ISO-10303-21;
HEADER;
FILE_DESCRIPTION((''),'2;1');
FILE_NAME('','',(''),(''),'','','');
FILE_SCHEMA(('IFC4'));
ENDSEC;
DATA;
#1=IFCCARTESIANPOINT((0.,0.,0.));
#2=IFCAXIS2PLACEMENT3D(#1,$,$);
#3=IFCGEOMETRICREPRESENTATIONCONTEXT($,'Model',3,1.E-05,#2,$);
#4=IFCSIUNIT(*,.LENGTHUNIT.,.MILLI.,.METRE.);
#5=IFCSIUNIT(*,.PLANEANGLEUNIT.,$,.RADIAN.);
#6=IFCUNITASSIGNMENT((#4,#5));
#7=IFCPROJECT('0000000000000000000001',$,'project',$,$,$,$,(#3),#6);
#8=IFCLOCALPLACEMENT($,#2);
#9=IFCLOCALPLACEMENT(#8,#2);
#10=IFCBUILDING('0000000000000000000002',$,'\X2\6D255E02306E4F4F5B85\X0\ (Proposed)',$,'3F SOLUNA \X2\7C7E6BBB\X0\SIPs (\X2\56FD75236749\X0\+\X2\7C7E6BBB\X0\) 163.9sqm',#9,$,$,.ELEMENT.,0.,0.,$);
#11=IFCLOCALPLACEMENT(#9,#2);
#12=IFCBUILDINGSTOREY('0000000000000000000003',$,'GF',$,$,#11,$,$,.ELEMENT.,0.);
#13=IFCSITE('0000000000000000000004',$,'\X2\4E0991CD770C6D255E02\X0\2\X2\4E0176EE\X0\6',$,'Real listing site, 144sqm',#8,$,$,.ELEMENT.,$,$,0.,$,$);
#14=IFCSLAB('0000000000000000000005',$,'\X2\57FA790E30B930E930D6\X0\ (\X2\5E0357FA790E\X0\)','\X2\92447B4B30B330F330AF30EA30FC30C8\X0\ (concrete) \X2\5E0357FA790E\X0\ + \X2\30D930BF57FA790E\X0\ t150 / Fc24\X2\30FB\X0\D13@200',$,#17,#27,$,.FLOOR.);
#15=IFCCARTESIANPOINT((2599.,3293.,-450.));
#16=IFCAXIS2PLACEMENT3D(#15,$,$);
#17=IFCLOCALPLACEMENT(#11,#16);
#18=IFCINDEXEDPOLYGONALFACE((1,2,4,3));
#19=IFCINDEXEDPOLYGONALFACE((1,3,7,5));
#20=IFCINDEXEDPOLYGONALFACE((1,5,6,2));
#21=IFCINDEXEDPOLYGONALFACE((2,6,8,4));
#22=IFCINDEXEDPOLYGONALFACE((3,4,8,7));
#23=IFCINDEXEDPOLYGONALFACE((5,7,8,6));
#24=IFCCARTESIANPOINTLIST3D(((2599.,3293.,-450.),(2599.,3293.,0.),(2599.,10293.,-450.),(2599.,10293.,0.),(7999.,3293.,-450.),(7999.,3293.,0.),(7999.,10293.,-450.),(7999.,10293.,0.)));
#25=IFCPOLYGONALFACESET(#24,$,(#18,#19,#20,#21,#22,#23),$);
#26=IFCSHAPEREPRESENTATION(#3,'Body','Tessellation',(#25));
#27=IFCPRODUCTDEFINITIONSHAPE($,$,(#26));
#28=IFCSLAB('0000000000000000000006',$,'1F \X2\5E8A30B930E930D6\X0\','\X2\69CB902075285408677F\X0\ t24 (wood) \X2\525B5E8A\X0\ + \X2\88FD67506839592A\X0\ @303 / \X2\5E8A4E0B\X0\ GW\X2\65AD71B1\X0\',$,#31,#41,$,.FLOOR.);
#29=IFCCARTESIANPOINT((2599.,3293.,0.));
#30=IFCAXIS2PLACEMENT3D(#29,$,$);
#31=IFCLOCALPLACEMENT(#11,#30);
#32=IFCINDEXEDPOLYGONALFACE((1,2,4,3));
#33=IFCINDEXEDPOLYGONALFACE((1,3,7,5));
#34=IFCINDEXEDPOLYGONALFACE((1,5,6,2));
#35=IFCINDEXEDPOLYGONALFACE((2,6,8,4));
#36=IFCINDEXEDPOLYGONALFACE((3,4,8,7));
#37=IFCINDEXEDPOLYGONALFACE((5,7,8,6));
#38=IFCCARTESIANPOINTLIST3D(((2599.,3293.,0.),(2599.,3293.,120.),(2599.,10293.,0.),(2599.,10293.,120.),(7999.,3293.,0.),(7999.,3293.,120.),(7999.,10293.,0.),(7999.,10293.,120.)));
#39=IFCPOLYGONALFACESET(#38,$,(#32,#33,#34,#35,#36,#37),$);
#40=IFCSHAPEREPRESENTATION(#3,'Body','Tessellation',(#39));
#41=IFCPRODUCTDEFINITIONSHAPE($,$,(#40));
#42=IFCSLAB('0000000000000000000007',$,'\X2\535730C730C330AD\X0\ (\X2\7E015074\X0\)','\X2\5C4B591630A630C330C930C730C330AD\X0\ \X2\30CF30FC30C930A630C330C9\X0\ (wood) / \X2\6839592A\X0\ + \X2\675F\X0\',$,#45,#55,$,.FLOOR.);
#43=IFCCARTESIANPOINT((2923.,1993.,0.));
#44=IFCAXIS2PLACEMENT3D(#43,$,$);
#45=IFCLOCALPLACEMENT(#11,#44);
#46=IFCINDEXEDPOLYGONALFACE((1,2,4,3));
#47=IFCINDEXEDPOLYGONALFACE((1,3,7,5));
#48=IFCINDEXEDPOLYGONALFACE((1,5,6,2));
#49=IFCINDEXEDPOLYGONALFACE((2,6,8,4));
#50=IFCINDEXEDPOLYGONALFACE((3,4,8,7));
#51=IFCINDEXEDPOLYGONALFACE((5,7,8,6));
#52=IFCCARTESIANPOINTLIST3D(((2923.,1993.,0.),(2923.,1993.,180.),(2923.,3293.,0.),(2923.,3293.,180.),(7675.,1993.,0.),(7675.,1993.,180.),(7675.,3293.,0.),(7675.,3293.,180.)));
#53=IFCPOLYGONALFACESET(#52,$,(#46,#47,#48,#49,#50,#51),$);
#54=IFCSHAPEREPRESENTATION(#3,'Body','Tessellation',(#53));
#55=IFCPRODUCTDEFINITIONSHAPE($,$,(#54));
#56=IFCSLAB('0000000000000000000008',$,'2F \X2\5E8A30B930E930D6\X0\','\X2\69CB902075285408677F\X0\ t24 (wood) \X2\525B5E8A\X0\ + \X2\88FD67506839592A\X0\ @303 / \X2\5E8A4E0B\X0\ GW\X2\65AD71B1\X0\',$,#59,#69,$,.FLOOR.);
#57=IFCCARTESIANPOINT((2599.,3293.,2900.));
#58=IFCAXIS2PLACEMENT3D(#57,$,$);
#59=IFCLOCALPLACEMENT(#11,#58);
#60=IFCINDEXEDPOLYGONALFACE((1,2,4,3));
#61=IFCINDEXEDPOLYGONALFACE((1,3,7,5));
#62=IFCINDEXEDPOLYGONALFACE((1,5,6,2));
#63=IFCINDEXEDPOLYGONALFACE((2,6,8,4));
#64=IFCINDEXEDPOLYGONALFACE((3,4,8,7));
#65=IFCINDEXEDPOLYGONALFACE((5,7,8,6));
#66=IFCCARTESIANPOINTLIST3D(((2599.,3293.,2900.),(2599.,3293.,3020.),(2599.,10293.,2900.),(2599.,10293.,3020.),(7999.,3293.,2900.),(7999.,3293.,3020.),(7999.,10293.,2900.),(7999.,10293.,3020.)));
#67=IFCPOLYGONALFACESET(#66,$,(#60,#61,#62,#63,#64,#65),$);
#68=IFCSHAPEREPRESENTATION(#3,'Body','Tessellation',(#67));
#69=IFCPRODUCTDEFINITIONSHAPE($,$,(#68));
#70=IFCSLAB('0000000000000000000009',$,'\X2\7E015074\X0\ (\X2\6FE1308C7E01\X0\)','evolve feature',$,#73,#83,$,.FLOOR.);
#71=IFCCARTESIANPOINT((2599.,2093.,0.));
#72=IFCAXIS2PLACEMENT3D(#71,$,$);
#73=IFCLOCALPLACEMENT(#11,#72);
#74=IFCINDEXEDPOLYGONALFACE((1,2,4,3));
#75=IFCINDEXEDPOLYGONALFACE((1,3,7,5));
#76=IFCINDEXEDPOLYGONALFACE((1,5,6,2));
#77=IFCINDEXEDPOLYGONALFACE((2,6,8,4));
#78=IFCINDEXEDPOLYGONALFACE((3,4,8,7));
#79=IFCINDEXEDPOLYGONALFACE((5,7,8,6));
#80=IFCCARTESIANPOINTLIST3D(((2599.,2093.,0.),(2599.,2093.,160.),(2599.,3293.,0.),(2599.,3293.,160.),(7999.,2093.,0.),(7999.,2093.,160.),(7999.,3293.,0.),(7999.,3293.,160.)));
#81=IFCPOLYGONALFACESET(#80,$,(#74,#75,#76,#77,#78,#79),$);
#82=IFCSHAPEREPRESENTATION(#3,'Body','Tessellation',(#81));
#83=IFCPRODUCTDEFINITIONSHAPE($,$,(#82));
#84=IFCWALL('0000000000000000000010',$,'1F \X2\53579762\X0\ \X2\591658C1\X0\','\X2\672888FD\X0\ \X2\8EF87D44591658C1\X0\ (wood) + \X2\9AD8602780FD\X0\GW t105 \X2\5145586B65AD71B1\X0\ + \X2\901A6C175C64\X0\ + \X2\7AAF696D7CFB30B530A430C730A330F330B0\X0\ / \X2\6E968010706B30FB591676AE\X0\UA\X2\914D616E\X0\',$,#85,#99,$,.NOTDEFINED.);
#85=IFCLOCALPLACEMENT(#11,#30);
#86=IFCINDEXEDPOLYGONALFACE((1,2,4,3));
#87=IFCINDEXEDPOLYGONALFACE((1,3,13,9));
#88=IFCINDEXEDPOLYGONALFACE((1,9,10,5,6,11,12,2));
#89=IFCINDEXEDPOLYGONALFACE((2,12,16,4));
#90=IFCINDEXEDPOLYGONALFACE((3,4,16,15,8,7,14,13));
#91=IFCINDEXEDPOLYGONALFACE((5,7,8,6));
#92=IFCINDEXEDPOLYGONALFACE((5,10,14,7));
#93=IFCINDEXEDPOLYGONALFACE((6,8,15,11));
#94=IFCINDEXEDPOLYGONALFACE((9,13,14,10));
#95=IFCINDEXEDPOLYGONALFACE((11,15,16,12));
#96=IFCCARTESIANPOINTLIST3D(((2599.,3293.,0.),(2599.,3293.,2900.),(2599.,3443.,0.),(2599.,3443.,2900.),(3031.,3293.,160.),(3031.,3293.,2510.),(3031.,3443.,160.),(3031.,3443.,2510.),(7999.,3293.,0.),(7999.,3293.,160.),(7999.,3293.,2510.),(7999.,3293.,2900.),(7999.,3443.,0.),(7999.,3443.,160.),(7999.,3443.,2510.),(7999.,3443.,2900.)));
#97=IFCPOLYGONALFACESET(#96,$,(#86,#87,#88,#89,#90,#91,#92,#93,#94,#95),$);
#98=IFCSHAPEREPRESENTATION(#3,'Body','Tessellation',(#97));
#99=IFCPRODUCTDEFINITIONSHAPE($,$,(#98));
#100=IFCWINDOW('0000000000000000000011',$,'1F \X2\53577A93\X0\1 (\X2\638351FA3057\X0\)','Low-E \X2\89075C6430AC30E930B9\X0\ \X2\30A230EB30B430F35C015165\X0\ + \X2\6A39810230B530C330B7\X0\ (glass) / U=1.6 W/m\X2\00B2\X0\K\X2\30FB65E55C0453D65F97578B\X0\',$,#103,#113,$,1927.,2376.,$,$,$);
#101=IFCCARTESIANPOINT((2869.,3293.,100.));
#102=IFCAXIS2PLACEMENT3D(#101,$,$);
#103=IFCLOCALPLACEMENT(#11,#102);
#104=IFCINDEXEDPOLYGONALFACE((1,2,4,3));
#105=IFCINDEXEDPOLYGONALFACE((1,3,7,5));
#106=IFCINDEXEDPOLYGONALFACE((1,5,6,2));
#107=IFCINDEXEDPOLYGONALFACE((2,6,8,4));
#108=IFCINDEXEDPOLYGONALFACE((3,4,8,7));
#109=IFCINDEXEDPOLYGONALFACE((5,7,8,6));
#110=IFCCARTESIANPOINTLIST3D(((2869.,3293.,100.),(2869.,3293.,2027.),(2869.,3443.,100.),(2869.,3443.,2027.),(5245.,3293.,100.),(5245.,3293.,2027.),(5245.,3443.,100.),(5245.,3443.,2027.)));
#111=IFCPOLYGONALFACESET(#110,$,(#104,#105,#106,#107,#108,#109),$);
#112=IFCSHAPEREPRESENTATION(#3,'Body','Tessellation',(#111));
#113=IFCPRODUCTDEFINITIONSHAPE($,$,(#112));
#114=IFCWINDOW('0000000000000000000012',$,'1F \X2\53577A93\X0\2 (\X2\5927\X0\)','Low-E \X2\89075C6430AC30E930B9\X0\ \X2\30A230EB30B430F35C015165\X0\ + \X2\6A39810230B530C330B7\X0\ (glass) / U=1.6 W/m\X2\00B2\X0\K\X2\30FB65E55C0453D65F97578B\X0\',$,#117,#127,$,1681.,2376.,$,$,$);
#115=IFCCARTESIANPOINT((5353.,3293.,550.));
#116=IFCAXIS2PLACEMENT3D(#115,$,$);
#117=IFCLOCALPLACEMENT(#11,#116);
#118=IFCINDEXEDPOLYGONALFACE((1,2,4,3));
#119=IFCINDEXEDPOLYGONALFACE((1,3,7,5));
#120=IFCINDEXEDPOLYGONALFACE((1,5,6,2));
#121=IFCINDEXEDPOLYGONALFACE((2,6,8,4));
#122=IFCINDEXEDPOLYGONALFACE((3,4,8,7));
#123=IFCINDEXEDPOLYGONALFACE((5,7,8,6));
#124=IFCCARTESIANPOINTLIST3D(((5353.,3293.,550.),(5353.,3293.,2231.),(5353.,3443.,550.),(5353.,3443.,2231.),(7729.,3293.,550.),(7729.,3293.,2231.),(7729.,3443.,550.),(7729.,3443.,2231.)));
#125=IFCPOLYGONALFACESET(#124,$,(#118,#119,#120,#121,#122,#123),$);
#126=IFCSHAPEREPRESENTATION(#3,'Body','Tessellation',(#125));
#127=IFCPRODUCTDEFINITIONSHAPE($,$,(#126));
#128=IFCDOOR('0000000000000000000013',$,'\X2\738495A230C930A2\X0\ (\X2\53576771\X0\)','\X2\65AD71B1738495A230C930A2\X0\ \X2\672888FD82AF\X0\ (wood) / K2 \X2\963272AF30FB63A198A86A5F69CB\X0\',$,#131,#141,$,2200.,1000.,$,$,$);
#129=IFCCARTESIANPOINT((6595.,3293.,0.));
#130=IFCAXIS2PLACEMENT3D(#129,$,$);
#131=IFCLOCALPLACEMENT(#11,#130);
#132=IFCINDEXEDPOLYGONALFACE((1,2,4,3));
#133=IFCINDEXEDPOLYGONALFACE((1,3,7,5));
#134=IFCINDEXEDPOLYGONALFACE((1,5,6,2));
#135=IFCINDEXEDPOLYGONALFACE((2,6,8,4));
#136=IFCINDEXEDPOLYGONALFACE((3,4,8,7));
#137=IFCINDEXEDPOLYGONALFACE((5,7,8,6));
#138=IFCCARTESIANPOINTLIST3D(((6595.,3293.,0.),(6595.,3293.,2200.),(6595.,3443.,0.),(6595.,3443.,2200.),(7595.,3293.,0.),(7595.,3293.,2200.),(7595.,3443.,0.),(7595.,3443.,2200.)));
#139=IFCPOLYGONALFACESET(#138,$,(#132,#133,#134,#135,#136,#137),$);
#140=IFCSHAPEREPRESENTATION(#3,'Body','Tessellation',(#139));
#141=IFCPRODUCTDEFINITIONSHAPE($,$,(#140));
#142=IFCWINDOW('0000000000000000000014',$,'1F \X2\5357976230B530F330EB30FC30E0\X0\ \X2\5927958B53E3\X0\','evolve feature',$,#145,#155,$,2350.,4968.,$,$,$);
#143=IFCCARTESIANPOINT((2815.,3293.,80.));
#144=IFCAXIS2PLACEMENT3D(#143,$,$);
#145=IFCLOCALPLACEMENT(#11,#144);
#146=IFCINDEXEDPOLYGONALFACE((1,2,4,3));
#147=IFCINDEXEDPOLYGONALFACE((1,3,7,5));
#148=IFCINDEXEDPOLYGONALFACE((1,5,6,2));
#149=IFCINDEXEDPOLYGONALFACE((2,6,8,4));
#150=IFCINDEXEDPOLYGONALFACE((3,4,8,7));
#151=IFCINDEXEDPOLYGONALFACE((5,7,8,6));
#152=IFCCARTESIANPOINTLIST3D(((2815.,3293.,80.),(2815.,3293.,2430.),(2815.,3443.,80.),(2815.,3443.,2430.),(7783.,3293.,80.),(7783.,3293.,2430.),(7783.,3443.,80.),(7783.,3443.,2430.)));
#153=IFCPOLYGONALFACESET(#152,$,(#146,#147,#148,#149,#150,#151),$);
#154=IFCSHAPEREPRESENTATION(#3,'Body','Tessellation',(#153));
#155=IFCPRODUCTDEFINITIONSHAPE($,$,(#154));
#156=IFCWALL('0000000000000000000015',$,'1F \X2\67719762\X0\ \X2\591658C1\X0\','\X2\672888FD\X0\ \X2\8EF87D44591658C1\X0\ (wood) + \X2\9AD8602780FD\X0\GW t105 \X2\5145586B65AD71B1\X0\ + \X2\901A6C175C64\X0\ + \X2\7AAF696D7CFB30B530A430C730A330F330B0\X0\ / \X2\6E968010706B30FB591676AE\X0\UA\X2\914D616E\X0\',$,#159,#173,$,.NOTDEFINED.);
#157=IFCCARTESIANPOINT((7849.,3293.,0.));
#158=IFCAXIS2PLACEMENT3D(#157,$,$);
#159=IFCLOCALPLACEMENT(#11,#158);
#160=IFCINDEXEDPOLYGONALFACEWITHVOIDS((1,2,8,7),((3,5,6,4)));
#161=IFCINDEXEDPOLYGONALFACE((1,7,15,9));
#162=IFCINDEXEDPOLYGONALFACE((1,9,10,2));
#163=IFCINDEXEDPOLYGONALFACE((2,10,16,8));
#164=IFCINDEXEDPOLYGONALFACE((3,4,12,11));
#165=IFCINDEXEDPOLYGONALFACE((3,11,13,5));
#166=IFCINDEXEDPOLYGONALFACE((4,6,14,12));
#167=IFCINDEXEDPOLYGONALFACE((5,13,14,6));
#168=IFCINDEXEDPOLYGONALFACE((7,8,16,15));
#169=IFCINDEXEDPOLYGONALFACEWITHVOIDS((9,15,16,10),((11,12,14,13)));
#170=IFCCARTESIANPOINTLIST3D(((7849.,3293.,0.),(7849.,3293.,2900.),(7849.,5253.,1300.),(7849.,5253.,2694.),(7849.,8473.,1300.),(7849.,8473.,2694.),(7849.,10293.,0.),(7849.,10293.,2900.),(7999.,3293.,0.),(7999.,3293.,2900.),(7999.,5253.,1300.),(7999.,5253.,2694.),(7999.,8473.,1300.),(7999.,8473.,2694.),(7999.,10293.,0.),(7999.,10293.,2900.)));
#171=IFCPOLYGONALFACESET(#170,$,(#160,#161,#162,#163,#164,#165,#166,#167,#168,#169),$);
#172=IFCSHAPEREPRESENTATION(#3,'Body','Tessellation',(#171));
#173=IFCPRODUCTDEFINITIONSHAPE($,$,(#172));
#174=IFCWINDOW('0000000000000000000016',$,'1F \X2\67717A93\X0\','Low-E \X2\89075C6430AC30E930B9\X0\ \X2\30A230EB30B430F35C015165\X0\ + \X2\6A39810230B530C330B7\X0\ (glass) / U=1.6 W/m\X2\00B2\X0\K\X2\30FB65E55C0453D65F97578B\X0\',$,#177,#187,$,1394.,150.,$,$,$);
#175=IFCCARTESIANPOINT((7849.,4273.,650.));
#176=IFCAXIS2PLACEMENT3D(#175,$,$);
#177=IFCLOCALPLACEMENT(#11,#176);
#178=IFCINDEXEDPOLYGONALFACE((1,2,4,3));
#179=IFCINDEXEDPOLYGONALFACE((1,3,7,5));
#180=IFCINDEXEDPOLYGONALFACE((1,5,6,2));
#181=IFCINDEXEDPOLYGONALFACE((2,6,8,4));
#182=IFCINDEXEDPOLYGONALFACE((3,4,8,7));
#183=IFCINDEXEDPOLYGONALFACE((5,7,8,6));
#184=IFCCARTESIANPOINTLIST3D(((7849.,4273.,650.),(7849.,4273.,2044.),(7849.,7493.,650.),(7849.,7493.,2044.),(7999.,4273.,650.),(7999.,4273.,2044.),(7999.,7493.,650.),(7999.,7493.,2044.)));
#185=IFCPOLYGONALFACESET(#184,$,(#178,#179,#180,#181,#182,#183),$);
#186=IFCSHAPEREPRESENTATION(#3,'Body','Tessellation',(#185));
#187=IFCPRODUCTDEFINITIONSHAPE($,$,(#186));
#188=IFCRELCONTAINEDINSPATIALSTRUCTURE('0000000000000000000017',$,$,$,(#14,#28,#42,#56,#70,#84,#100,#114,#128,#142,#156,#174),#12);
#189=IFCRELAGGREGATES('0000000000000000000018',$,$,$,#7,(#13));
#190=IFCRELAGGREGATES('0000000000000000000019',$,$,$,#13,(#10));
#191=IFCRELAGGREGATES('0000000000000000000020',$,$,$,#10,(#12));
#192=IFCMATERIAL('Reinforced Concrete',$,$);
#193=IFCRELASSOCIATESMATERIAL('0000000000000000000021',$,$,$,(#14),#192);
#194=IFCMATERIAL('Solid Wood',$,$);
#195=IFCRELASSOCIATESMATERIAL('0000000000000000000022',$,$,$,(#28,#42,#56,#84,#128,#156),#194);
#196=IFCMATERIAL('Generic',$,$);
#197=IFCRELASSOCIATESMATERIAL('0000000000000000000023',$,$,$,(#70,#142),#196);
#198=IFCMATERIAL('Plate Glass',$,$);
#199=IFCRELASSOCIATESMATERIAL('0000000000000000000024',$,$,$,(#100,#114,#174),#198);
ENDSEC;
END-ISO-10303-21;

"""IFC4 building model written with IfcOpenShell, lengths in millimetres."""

from ifc_helpers import new_model, si_unit, frame, frame_2d, origin, place, context, project, spatial, rectangle, extrude, material, element, fill, save


model = new_model("IFC4")

# Units and contexts
model_context = context("Model", 3, precision=1e-05, world=origin())
ifc_project = project(units=[si_unit("LENGTHUNIT", "METRE", prefix="MILLI"), si_unit("PLANEANGLEUNIT", "RADIAN")], contexts=[model_context])

# Site, building, storey
site_placement = place(None, origin())
site = spatial("IfcSite", under=ifc_project, at=site_placement, Name="三重県津市2丁目6", ObjectType="Real listing site, 144sqm", CompositionType="ELEMENT", RefElevation=0.0)
building_placement = place(site_placement, origin())
building = spatial("IfcBuilding", under=site, at=building_placement, Name="津市の住宅 (Proposed)", ObjectType="3F SOLUNA 籾殻SIPs (国産杉+籾殻) 163.9sqm", CompositionType="ELEMENT", ElevationOfRefHeight=0.0, ElevationOfTerrain=0.0)
storey_placement = place(building_placement, origin())
storey = spatial("IfcBuildingStorey", under=building, at=storey_placement, Name="GF", CompositionType="ELEMENT", Elevation=0.0)

# Slabs
ifc_material_1 = material(Name="Reinforced Concrete")
slab_1_placement = place(storey_placement, frame((2599.0, 3293.0, -450.0)))
element("IfcSlab", 1, at=slab_1_placement, inside=storey, material=ifc_material_1, Name="基礎スラブ (布基礎)", Description="鉄筋コンクリート (concrete) 布基礎 + ベタ基礎 t150 / Fc24・D13@200", PredefinedType="FLOOR", context=model_context, shape_type="SweptSolid", body=[
    extrude(rectangle(XDim=5400.0, YDim=7000.0, at=frame_2d((2700.0, 3500.0))), frame((2599.0, 3293.0, -450.0)), (0.0, 0.0, 1.0), 450.0),
])
ifc_material_2 = material(Name="Solid Wood")
slab_2_placement = place(storey_placement, frame((2599.0, 3293.0, 0.0)))
element("IfcSlab", 2, at=slab_2_placement, inside=storey, material=ifc_material_2, Name="1F 床スラブ", Description="構造用合板 t24 (wood) 剛床 + 製材根太 @303 / 床下 GW断熱", PredefinedType="FLOOR", context=model_context, shape_type="SweptSolid", body=[
    extrude(rectangle(XDim=5400.0, YDim=7000.0, at=frame_2d((2700.0, 3500.0))), frame((2599.0, 3293.0, 0.0)), (0.0, 0.0, 1.0), 120.0),
])
slab_3_placement = place(storey_placement, frame((2923.0, 1993.0, 0.0)))
element("IfcSlab", 3, at=slab_3_placement, inside=storey, material=ifc_material_2, Name="南デッキ (縁側)", Description="屋外ウッドデッキ ハードウッド (wood) / 根太 + 束", PredefinedType="FLOOR", context=model_context, shape_type="SweptSolid", body=[
    extrude(rectangle(XDim=4752.0, YDim=1300.0, at=frame_2d((2376.0, 650.0))), frame((2923.0, 1993.0, 0.0)), (0.0, 0.0, 1.0), 180.0),
])
slab_4_placement = place(storey_placement, frame((2599.0, 3293.0, 2900.0)))
element("IfcSlab", 4, at=slab_4_placement, inside=storey, material=ifc_material_2, Name="2F 床スラブ", Description="構造用合板 t24 (wood) 剛床 + 製材根太 @303 / 床下 GW断熱", PredefinedType="FLOOR", context=model_context, shape_type="SweptSolid", body=[
    extrude(rectangle(XDim=5400.0, YDim=7000.0, at=frame_2d((2700.0, 3500.0))), frame((2599.0, 3293.0, 2900.0)), (0.0, 0.0, 1.0), 120.0),
])
ifc_material_3 = material(Name="Generic")
slab_5_placement = place(storey_placement, frame((2599.0, 2093.0, 0.0)))
element("IfcSlab", 5, at=slab_5_placement, inside=storey, material=ifc_material_3, Name="縁側 (濡れ縁)", Description="evolve feature", PredefinedType="FLOOR", context=model_context, shape_type="SweptSolid", body=[
    extrude(rectangle(XDim=5400.0, YDim=1200.0, at=frame_2d((2700.0, 600.0))), frame((2599.0, 2093.0, 0.0)), (0.0, 0.0, 1.0), 160.0),
])

# Wall, openings, windows, door
wall_1_placement = place(storey_placement, frame((2599.0, 3293.0, 0.0)))
wall_1 = element("IfcWall", 6, at=wall_1_placement, inside=storey, material=ifc_material_2, Name="1F 南面 外壁", Description="木製 軸組外壁 (wood) + 高性能GW t105 充填断熱 + 通気層 + 窯業系サイディング / 準耐火・外皮UA配慮", PredefinedType="NOTDEFINED", context=model_context, shape_type="SweptSolid", body=[
    extrude(rectangle(XDim=5400.0, YDim=150.0, at=frame_2d((2700.0, 75.0))), frame((2599.0, 3293.0, 0.0)), (0.0, 0.0, 1.0), 2900.0),
])
opening_1_placement = place(storey_placement, frame((2869.0, 3293.0, 100.0)))
opening_1 = element("IfcOpeningElement", 7, at=opening_1_placement, cuts=wall_1, PredefinedType="NOTDEFINED", context=model_context, shape_type="SweptSolid", body=[
    extrude(rectangle(XDim=2376.0, YDim=150.0, at=frame_2d((1188.0, 75.0))), frame((2869.0, 3293.0, 100.0)), (0.0, 0.0, 1.0), 1927.0),
])
opening_2_placement = place(storey_placement, frame((5353.0, 3293.0, 550.0)))
opening_2 = element("IfcOpeningElement", 8, at=opening_2_placement, cuts=wall_1, PredefinedType="NOTDEFINED", context=model_context, shape_type="SweptSolid", body=[
    extrude(rectangle(XDim=2376.0, YDim=150.0, at=frame_2d((1188.0, 75.0))), frame((5353.0, 3293.0, 550.0)), (0.0, 0.0, 1.0), 1681.0),
])
opening_3_placement = place(storey_placement, frame((6595.0, 3293.0, 0.0)))
opening_3 = element("IfcOpeningElement", 9, at=opening_3_placement, cuts=wall_1, PredefinedType="NOTDEFINED", context=model_context, shape_type="SweptSolid", body=[
    extrude(rectangle(XDim=1000.0, YDim=150.0, at=frame_2d((500.0, 75.0))), frame((6595.0, 3293.0, 0.0)), (0.0, 0.0, 1.0), 2200.0),
])
opening_4_placement = place(storey_placement, frame((2815.0, 3293.0, 80.0)))
opening_4 = element("IfcOpeningElement", 10, at=opening_4_placement, cuts=wall_1, PredefinedType="NOTDEFINED", context=model_context, shape_type="SweptSolid", body=[
    extrude(rectangle(XDim=4968.0, YDim=150.0, at=frame_2d((2484.0, 75.0))), frame((2815.0, 3293.0, 80.0)), (0.0, 0.0, 1.0), 2350.0),
])
ifc_material_4 = material(Name="Plate Glass")
window_1_placement = place(storey_placement, frame((2869.0, 3293.0, 100.0)))
window_1 = element("IfcWindow", 11, at=window_1_placement, inside=storey, material=ifc_material_4, Name="1F 南窓1 (掃出し)", Description="Low-E 複層ガラス アルゴン封入 + 樹脂サッシ (glass) / U=1.6 W/m²K・日射取得型", OverallHeight=1927.0, OverallWidth=2376.0, context=model_context, shape_type="SweptSolid", body=[
    extrude(rectangle(XDim=2376.0, YDim=150.0, at=frame_2d((1188.0, 75.0))), frame((2869.0, 3293.0, 100.0)), (0.0, 0.0, 1.0), 1927.0),
])
fill(opening_1, window_1)
window_2_placement = place(storey_placement, frame((5353.0, 3293.0, 550.0)))
window_2 = element("IfcWindow", 12, at=window_2_placement, inside=storey, material=ifc_material_4, Name="1F 南窓2 (大)", Description="Low-E 複層ガラス アルゴン封入 + 樹脂サッシ (glass) / U=1.6 W/m²K・日射取得型", OverallHeight=1681.0, OverallWidth=2376.0, context=model_context, shape_type="SweptSolid", body=[
    extrude(rectangle(XDim=2376.0, YDim=150.0, at=frame_2d((1188.0, 75.0))), frame((5353.0, 3293.0, 550.0)), (0.0, 0.0, 1.0), 1681.0),
])
fill(opening_2, window_2)
door_placement = place(storey_placement, frame((6595.0, 3293.0, 0.0)))
door = element("IfcDoor", 13, at=door_placement, inside=storey, material=ifc_material_2, Name="玄関ドア (南東)", Description="断熱玄関ドア 木製芯 (wood) / K2 防犯・採風機構", OverallHeight=2200.0, OverallWidth=1000.0, context=model_context, shape_type="SweptSolid", body=[
    extrude(rectangle(XDim=1000.0, YDim=150.0, at=frame_2d((500.0, 75.0))), frame((6595.0, 3293.0, 0.0)), (0.0, 0.0, 1.0), 2200.0),
])
fill(opening_3, door)
window_3_placement = place(storey_placement, frame((2815.0, 3293.0, 80.0)))
window_3 = element("IfcWindow", 14, at=window_3_placement, inside=storey, material=ifc_material_3, Name="1F 南面サンルーム 大開口", Description="evolve feature", OverallHeight=2350.0, OverallWidth=4968.0, context=model_context, shape_type="SweptSolid", body=[
    extrude(rectangle(XDim=4968.0, YDim=150.0, at=frame_2d((2484.0, 75.0))), frame((2815.0, 3293.0, 80.0)), (0.0, 0.0, 1.0), 2350.0),
])
fill(opening_4, window_3)

# Wall, opening, window
wall_2_placement = place(storey_placement, frame((7849.0, 3293.0, 0.0)))
wall_2 = element("IfcWall", 15, at=wall_2_placement, inside=storey, material=ifc_material_2, Name="1F 東面 外壁", Description="木製 軸組外壁 (wood) + 高性能GW t105 充填断熱 + 通気層 + 窯業系サイディング / 準耐火・外皮UA配慮", PredefinedType="NOTDEFINED", context=model_context, shape_type="SweptSolid", body=[
    extrude(rectangle(XDim=150.0, YDim=7000.0, at=frame_2d((75.0, 3500.0))), frame((7849.0, 3293.0, 0.0)), (0.0, 0.0, 1.0), 2900.0),
])
opening_5_placement = place(storey_placement, frame((7849.0, 4273.0, 650.0)))
opening_5 = element("IfcOpeningElement", 16, at=opening_5_placement, cuts=wall_2, PredefinedType="NOTDEFINED", context=model_context, shape_type="SweptSolid", body=[
    extrude(rectangle(XDim=150.0, YDim=3220.0, at=frame_2d((75.0, 1610.0))), frame((7849.0, 4273.0, 650.0)), (0.0, 0.0, 1.0), 1394.0),
])
window_4_placement = place(storey_placement, frame((7849.0, 4273.0, 650.0)))
window_4 = element("IfcWindow", 17, at=window_4_placement, inside=storey, material=ifc_material_4, Name="1F 東窓", Description="Low-E 複層ガラス アルゴン封入 + 樹脂サッシ (glass) / U=1.6 W/m²K・日射取得型", OverallHeight=1394.0, OverallWidth=150.0, context=model_context, shape_type="SweptSolid", body=[
    extrude(rectangle(XDim=150.0, YDim=3220.0, at=frame_2d((75.0, 1610.0))), frame((7849.0, 4273.0, 650.0)), (0.0, 0.0, 1.0), 1394.0),
])
fill(opening_5, window_4)

save(model, "model.ifc")
